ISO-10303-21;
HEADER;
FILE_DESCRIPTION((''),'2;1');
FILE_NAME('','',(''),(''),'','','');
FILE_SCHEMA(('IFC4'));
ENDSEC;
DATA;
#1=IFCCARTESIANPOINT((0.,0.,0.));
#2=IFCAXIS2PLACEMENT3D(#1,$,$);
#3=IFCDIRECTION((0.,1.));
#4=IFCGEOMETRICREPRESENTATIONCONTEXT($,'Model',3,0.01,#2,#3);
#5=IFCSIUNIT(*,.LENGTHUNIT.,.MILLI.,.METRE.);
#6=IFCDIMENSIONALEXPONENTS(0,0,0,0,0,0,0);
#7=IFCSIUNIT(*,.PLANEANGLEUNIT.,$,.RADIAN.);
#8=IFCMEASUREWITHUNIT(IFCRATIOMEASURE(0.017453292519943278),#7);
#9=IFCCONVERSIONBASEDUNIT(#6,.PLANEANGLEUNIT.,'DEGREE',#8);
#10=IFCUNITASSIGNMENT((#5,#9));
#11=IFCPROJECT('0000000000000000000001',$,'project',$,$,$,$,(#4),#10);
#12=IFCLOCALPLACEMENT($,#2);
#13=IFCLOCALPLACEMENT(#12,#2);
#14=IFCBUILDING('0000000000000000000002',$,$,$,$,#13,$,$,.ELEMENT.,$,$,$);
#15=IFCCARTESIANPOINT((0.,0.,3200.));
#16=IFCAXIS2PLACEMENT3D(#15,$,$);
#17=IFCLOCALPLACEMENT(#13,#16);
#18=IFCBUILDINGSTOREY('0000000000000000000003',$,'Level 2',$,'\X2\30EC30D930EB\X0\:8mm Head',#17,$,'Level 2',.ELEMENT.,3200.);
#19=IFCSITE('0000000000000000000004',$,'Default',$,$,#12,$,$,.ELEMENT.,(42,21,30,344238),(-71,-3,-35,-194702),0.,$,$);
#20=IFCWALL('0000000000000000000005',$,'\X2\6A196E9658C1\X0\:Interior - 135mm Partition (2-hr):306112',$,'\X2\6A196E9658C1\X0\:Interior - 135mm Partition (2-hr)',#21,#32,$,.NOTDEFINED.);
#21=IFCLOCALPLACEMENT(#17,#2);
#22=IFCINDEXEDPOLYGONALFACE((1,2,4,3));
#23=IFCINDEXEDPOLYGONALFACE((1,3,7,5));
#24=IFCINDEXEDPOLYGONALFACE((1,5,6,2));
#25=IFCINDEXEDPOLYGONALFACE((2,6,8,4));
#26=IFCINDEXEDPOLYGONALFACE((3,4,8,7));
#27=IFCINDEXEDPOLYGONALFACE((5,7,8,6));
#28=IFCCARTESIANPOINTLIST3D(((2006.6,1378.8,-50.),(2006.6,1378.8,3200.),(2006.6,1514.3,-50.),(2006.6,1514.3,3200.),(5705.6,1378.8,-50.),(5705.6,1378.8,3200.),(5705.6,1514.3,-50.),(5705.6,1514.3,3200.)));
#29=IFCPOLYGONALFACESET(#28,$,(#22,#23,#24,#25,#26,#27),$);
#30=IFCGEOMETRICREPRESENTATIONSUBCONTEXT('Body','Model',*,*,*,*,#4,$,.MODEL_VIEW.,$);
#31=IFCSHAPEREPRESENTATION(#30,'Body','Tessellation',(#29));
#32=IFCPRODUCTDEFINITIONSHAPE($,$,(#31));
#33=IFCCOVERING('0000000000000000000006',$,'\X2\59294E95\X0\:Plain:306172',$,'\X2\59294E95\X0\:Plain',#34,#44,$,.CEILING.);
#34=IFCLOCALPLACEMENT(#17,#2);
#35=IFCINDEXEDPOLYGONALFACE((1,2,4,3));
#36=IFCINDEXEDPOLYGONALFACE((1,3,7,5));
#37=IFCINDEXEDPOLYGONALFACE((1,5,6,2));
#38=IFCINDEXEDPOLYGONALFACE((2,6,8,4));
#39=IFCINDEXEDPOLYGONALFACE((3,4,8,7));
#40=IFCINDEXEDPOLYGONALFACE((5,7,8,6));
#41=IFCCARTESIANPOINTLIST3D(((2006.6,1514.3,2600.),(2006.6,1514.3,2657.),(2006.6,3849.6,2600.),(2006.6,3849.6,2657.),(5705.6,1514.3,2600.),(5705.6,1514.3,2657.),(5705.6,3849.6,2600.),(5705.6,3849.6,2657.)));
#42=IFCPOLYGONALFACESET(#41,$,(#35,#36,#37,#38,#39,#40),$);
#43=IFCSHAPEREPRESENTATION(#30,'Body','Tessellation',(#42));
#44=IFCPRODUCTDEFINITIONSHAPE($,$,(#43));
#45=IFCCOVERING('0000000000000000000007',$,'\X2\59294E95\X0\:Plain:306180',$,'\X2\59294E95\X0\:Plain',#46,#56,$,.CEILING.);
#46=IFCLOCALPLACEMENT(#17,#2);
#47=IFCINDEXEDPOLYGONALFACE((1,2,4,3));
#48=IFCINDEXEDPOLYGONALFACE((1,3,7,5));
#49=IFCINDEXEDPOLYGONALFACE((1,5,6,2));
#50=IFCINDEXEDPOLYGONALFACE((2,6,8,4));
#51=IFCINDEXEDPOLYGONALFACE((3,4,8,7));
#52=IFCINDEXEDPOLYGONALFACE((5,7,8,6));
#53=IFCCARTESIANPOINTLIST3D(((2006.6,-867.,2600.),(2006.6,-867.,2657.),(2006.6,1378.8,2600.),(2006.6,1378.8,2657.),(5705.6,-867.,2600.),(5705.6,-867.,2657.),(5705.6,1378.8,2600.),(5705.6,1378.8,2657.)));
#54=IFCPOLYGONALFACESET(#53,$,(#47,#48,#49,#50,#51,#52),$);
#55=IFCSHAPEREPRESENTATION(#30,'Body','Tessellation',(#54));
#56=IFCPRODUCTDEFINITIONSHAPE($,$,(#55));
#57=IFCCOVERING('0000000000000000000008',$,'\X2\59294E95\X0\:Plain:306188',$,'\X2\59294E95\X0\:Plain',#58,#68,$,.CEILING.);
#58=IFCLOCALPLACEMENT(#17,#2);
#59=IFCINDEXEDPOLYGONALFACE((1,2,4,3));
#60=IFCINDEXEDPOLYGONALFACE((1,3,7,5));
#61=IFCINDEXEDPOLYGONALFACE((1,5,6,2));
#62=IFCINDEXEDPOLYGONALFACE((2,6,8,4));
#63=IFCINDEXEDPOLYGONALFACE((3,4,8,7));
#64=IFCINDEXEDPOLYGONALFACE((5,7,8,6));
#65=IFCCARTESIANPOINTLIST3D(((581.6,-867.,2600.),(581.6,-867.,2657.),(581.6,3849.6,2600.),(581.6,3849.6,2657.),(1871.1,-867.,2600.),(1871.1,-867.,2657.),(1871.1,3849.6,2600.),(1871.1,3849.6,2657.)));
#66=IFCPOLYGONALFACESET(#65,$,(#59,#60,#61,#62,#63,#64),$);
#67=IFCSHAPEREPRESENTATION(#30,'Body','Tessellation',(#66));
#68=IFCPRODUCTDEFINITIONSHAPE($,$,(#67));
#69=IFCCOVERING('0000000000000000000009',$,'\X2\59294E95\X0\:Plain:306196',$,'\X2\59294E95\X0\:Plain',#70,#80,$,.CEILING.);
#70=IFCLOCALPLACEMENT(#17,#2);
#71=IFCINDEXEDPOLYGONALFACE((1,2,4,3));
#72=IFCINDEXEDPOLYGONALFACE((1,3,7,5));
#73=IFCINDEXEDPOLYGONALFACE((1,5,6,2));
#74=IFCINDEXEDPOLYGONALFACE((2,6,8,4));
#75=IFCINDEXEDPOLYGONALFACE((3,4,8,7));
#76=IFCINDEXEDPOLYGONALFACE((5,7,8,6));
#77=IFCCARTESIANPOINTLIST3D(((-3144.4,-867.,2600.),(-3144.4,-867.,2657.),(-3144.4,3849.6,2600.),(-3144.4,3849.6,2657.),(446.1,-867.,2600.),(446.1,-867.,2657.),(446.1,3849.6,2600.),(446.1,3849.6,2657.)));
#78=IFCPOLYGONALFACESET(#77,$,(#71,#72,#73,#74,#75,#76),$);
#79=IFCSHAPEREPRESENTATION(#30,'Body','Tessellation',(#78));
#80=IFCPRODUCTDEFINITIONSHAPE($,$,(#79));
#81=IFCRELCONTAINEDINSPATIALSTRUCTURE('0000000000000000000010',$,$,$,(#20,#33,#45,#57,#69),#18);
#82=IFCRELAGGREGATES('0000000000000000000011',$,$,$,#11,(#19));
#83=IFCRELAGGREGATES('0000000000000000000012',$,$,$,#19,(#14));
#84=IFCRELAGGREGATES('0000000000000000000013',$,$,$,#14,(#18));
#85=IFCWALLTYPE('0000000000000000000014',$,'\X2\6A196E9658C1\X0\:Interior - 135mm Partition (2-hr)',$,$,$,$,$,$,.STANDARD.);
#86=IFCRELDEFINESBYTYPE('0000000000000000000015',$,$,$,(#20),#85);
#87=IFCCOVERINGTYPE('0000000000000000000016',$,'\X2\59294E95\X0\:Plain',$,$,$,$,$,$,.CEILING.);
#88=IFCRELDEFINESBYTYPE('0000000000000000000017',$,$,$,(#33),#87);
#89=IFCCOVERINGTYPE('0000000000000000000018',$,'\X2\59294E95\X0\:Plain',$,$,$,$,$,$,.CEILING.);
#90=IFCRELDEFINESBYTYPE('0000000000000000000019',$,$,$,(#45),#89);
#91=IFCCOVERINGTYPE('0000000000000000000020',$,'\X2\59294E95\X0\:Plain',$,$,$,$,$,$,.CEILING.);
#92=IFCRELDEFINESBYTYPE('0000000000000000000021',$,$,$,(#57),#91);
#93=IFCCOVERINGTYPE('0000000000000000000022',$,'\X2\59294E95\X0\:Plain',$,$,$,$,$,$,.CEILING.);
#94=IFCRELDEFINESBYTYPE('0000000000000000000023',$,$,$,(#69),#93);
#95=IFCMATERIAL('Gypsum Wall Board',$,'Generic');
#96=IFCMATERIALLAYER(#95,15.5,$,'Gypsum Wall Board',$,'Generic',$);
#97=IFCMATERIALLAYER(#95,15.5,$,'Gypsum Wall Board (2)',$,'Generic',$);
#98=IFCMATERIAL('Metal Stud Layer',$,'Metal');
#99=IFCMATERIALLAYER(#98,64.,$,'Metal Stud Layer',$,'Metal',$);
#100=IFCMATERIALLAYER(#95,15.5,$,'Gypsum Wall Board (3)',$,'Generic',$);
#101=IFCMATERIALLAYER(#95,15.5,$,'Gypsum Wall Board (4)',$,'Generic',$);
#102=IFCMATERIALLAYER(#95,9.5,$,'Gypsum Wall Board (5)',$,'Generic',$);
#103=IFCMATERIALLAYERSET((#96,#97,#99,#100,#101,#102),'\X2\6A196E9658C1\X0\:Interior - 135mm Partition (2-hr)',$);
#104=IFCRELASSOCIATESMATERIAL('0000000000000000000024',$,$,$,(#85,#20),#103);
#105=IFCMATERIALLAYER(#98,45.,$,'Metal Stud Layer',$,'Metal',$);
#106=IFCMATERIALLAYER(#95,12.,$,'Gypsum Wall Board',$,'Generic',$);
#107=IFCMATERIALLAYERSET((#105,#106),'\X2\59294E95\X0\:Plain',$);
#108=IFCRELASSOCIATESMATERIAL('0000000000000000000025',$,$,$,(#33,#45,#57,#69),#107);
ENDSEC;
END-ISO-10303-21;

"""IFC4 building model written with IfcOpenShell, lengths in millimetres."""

from ifc_helpers import new_model, entity, si_unit, converted_unit, direction, frame, frame_2d, origin, place, context, subcontext, project, spatial, rectangle, extrude, material, layer, layer_set, layer_usage, type_object, element, save


model = new_model("IFC4")

# Units and contexts
model_context = context("Model", 3, precision=0.01, world=origin(), true_north=direction((0.0, 1.0)))
body_context = subcontext(model_context, "Body", "Model", "MODEL_VIEW")
ifc_project = project(units=[si_unit("LENGTHUNIT", "METRE", prefix="MILLI"), converted_unit("PLANEANGLEUNIT", "DEGREE", entity("IfcRatioMeasure", 0.017453292519943278), si_unit("PLANEANGLEUNIT", "RADIAN"), dimensions=[0, 0, 0, 0, 0, 0, 0])], contexts=[model_context])

# Site, building, storey
site_placement = place(None, origin())
site = spatial("IfcSite", under=ifc_project, at=site_placement, Name="Default", CompositionType="ELEMENT", RefLatitude=(42, 21, 30, 344238), RefLongitude=(-71, -3, -35, -194702), RefElevation=0.0)
building_placement = place(site_placement, origin())
building = spatial("IfcBuilding", under=site, at=building_placement, CompositionType="ELEMENT")
storey_placement = place(building_placement, frame((0.0, 0.0, 3200.0)))
storey = spatial("IfcBuildingStorey", under=building, at=storey_placement, Name="Level 2", ObjectType="レベル:8mm Head", LongName="Level 2", CompositionType="ELEMENT", Elevation=3200.0)

# Wall
ifc_material_1 = material(Name="Gypsum Wall Board", Category="Generic")
ifc_layer_1 = layer(ifc_material_1, 15.5, Name="Gypsum Wall Board", Category="Generic")
ifc_layer_2 = layer(ifc_material_1, 15.5, Name="Gypsum Wall Board (2)", Category="Generic")
ifc_material_2 = material(Name="Metal Stud Layer", Category="Metal")
ifc_layer_3 = layer(ifc_material_2, 64.0, Name="Metal Stud Layer", Category="Metal")
ifc_layer_4 = layer(ifc_material_1, 15.5, Name="Gypsum Wall Board (3)", Category="Generic")
ifc_layer_5 = layer(ifc_material_1, 15.5, Name="Gypsum Wall Board (4)", Category="Generic")
ifc_layer_6 = layer(ifc_material_1, 9.5, Name="Gypsum Wall Board (5)", Category="Generic")
ifc_layer_set_1 = layer_set([ifc_layer_1, ifc_layer_2, ifc_layer_3, ifc_layer_4, ifc_layer_5, ifc_layer_6], Name="標準壁:Interior - 135mm Partition (2-hr)")
ifc_layer_usage_1 = layer_usage(ifc_layer_set_1, "AXIS2", "NEGATIVE", 67.8)
wall_type = type_object("IfcWallType", Name="標準壁:Interior - 135mm Partition (2-hr)", PredefinedType="STANDARD", material=ifc_layer_set_1)
wall_placement = place(storey_placement, frame((2006.6, 1446.6, -50.0)))
element("IfcWall", 1, at=wall_placement, inside=storey, type_object=wall_type, material=ifc_layer_usage_1, Name="標準壁:Interior - 135mm Partition (2-hr):306112", ObjectType="標準壁:Interior - 135mm Partition (2-hr)", PredefinedType="NOTDEFINED", context=body_context, shape_type="SweptSolid", body=[
    extrude(rectangle(XDim=3698.9, YDim=135.5, at=frame_2d((1849.5, 0.0), x_axis=(-1.0, 0.0))), origin(), (0.0, 0.0, 1.0), 3250.0),
])

# Coverings
ifc_layer_7 = layer(ifc_material_2, 45.0, Name="Metal Stud Layer", Category="Metal")
ifc_layer_8 = layer(ifc_material_1, 12.0, Name="Gypsum Wall Board", Category="Generic")
ifc_layer_set_2 = layer_set([ifc_layer_7, ifc_layer_8], Name="天井:Plain")
ifc_layer_usage_2 = layer_usage(ifc_layer_set_2, "AXIS3", "POSITIVE", 0.0)
covering_type_1 = type_object("IfcCoveringType", Name="天井:Plain", PredefinedType="CEILING")
covering_1_placement = place(storey_placement, frame((2006.6, 1514.3, 2600.0)))
element("IfcCovering", 2, at=covering_1_placement, inside=storey, type_object=covering_type_1, material=ifc_layer_usage_2, Name="天井:Plain:306172", ObjectType="天井:Plain", PredefinedType="CEILING", context=body_context, shape_type="SweptSolid", body=[
    extrude(rectangle(XDim=3698.9, YDim=2335.3, at=frame_2d((0.0, 0.0), x_axis=(1.0, 0.0))), frame((1849.5, 1167.6, 0.0), z_axis=(0.0, 0.0, 1.0), x_axis=(-1.0, 0.0, 0.0)), (0.0, 0.0, 1.0), 57.0),
])
ifc_layer_usage_3 = layer_usage(ifc_layer_set_2, "AXIS3", "POSITIVE", 0.0)
covering_type_2 = type_object("IfcCoveringType", Name="天井:Plain", PredefinedType="CEILING")
covering_2_placement = place(storey_placement, frame((2006.6, -867.0, 2600.0)))
element("IfcCovering", 3, at=covering_2_placement, inside=storey, type_object=covering_type_2, material=ifc_layer_usage_3, Name="天井:Plain:306180", ObjectType="天井:Plain", PredefinedType="CEILING", context=body_context, shape_type="SweptSolid", body=[
    extrude(rectangle(XDim=2245.8, YDim=3698.9, at=frame_2d((0.0, 0.0), x_axis=(1.0, 0.0))), frame((1849.5, 1122.9, 0.0), z_axis=(0.0, 0.0, 1.0), x_axis=(0.0, 1.0, 0.0)), (0.0, 0.0, 1.0), 57.0),
])
ifc_layer_usage_4 = layer_usage(ifc_layer_set_2, "AXIS3", "POSITIVE", 0.0)
covering_type_3 = type_object("IfcCoveringType", Name="天井:Plain", PredefinedType="CEILING")
covering_3_placement = place(storey_placement, frame((581.6, -867.0, 2600.0)))
element("IfcCovering", 4, at=covering_3_placement, inside=storey, type_object=covering_type_3, material=ifc_layer_usage_4, Name="天井:Plain:306188", ObjectType="天井:Plain", PredefinedType="CEILING", context=body_context, shape_type="SweptSolid", body=[
    extrude(rectangle(XDim=4716.6, YDim=1289.5, at=frame_2d((0.0, 0.0), x_axis=(1.0, 0.0))), frame((644.8, 2358.3, 0.0), z_axis=(0.0, 0.0, 1.0), x_axis=(0.0, 1.0, 0.0)), (0.0, 0.0, 1.0), 57.0),
])
ifc_layer_usage_5 = layer_usage(ifc_layer_set_2, "AXIS3", "POSITIVE", 0.0)
covering_type_4 = type_object("IfcCoveringType", Name="天井:Plain", PredefinedType="CEILING")
covering_4_placement = place(storey_placement, frame((-3144.4, -867.0, 2600.0)))
element("IfcCovering", 5, at=covering_4_placement, inside=storey, type_object=covering_type_4, material=ifc_layer_usage_5, Name="天井:Plain:306196", ObjectType="天井:Plain", PredefinedType="CEILING", context=body_context, shape_type="SweptSolid", body=[
    extrude(rectangle(XDim=3590.6, YDim=4716.6, at=frame_2d((0.0, 0.0), x_axis=(1.0, 0.0))), frame((1795.3, 2358.3, 0.0)), (0.0, 0.0, 1.0), 57.0),
])

save(model, "model.ifc")
